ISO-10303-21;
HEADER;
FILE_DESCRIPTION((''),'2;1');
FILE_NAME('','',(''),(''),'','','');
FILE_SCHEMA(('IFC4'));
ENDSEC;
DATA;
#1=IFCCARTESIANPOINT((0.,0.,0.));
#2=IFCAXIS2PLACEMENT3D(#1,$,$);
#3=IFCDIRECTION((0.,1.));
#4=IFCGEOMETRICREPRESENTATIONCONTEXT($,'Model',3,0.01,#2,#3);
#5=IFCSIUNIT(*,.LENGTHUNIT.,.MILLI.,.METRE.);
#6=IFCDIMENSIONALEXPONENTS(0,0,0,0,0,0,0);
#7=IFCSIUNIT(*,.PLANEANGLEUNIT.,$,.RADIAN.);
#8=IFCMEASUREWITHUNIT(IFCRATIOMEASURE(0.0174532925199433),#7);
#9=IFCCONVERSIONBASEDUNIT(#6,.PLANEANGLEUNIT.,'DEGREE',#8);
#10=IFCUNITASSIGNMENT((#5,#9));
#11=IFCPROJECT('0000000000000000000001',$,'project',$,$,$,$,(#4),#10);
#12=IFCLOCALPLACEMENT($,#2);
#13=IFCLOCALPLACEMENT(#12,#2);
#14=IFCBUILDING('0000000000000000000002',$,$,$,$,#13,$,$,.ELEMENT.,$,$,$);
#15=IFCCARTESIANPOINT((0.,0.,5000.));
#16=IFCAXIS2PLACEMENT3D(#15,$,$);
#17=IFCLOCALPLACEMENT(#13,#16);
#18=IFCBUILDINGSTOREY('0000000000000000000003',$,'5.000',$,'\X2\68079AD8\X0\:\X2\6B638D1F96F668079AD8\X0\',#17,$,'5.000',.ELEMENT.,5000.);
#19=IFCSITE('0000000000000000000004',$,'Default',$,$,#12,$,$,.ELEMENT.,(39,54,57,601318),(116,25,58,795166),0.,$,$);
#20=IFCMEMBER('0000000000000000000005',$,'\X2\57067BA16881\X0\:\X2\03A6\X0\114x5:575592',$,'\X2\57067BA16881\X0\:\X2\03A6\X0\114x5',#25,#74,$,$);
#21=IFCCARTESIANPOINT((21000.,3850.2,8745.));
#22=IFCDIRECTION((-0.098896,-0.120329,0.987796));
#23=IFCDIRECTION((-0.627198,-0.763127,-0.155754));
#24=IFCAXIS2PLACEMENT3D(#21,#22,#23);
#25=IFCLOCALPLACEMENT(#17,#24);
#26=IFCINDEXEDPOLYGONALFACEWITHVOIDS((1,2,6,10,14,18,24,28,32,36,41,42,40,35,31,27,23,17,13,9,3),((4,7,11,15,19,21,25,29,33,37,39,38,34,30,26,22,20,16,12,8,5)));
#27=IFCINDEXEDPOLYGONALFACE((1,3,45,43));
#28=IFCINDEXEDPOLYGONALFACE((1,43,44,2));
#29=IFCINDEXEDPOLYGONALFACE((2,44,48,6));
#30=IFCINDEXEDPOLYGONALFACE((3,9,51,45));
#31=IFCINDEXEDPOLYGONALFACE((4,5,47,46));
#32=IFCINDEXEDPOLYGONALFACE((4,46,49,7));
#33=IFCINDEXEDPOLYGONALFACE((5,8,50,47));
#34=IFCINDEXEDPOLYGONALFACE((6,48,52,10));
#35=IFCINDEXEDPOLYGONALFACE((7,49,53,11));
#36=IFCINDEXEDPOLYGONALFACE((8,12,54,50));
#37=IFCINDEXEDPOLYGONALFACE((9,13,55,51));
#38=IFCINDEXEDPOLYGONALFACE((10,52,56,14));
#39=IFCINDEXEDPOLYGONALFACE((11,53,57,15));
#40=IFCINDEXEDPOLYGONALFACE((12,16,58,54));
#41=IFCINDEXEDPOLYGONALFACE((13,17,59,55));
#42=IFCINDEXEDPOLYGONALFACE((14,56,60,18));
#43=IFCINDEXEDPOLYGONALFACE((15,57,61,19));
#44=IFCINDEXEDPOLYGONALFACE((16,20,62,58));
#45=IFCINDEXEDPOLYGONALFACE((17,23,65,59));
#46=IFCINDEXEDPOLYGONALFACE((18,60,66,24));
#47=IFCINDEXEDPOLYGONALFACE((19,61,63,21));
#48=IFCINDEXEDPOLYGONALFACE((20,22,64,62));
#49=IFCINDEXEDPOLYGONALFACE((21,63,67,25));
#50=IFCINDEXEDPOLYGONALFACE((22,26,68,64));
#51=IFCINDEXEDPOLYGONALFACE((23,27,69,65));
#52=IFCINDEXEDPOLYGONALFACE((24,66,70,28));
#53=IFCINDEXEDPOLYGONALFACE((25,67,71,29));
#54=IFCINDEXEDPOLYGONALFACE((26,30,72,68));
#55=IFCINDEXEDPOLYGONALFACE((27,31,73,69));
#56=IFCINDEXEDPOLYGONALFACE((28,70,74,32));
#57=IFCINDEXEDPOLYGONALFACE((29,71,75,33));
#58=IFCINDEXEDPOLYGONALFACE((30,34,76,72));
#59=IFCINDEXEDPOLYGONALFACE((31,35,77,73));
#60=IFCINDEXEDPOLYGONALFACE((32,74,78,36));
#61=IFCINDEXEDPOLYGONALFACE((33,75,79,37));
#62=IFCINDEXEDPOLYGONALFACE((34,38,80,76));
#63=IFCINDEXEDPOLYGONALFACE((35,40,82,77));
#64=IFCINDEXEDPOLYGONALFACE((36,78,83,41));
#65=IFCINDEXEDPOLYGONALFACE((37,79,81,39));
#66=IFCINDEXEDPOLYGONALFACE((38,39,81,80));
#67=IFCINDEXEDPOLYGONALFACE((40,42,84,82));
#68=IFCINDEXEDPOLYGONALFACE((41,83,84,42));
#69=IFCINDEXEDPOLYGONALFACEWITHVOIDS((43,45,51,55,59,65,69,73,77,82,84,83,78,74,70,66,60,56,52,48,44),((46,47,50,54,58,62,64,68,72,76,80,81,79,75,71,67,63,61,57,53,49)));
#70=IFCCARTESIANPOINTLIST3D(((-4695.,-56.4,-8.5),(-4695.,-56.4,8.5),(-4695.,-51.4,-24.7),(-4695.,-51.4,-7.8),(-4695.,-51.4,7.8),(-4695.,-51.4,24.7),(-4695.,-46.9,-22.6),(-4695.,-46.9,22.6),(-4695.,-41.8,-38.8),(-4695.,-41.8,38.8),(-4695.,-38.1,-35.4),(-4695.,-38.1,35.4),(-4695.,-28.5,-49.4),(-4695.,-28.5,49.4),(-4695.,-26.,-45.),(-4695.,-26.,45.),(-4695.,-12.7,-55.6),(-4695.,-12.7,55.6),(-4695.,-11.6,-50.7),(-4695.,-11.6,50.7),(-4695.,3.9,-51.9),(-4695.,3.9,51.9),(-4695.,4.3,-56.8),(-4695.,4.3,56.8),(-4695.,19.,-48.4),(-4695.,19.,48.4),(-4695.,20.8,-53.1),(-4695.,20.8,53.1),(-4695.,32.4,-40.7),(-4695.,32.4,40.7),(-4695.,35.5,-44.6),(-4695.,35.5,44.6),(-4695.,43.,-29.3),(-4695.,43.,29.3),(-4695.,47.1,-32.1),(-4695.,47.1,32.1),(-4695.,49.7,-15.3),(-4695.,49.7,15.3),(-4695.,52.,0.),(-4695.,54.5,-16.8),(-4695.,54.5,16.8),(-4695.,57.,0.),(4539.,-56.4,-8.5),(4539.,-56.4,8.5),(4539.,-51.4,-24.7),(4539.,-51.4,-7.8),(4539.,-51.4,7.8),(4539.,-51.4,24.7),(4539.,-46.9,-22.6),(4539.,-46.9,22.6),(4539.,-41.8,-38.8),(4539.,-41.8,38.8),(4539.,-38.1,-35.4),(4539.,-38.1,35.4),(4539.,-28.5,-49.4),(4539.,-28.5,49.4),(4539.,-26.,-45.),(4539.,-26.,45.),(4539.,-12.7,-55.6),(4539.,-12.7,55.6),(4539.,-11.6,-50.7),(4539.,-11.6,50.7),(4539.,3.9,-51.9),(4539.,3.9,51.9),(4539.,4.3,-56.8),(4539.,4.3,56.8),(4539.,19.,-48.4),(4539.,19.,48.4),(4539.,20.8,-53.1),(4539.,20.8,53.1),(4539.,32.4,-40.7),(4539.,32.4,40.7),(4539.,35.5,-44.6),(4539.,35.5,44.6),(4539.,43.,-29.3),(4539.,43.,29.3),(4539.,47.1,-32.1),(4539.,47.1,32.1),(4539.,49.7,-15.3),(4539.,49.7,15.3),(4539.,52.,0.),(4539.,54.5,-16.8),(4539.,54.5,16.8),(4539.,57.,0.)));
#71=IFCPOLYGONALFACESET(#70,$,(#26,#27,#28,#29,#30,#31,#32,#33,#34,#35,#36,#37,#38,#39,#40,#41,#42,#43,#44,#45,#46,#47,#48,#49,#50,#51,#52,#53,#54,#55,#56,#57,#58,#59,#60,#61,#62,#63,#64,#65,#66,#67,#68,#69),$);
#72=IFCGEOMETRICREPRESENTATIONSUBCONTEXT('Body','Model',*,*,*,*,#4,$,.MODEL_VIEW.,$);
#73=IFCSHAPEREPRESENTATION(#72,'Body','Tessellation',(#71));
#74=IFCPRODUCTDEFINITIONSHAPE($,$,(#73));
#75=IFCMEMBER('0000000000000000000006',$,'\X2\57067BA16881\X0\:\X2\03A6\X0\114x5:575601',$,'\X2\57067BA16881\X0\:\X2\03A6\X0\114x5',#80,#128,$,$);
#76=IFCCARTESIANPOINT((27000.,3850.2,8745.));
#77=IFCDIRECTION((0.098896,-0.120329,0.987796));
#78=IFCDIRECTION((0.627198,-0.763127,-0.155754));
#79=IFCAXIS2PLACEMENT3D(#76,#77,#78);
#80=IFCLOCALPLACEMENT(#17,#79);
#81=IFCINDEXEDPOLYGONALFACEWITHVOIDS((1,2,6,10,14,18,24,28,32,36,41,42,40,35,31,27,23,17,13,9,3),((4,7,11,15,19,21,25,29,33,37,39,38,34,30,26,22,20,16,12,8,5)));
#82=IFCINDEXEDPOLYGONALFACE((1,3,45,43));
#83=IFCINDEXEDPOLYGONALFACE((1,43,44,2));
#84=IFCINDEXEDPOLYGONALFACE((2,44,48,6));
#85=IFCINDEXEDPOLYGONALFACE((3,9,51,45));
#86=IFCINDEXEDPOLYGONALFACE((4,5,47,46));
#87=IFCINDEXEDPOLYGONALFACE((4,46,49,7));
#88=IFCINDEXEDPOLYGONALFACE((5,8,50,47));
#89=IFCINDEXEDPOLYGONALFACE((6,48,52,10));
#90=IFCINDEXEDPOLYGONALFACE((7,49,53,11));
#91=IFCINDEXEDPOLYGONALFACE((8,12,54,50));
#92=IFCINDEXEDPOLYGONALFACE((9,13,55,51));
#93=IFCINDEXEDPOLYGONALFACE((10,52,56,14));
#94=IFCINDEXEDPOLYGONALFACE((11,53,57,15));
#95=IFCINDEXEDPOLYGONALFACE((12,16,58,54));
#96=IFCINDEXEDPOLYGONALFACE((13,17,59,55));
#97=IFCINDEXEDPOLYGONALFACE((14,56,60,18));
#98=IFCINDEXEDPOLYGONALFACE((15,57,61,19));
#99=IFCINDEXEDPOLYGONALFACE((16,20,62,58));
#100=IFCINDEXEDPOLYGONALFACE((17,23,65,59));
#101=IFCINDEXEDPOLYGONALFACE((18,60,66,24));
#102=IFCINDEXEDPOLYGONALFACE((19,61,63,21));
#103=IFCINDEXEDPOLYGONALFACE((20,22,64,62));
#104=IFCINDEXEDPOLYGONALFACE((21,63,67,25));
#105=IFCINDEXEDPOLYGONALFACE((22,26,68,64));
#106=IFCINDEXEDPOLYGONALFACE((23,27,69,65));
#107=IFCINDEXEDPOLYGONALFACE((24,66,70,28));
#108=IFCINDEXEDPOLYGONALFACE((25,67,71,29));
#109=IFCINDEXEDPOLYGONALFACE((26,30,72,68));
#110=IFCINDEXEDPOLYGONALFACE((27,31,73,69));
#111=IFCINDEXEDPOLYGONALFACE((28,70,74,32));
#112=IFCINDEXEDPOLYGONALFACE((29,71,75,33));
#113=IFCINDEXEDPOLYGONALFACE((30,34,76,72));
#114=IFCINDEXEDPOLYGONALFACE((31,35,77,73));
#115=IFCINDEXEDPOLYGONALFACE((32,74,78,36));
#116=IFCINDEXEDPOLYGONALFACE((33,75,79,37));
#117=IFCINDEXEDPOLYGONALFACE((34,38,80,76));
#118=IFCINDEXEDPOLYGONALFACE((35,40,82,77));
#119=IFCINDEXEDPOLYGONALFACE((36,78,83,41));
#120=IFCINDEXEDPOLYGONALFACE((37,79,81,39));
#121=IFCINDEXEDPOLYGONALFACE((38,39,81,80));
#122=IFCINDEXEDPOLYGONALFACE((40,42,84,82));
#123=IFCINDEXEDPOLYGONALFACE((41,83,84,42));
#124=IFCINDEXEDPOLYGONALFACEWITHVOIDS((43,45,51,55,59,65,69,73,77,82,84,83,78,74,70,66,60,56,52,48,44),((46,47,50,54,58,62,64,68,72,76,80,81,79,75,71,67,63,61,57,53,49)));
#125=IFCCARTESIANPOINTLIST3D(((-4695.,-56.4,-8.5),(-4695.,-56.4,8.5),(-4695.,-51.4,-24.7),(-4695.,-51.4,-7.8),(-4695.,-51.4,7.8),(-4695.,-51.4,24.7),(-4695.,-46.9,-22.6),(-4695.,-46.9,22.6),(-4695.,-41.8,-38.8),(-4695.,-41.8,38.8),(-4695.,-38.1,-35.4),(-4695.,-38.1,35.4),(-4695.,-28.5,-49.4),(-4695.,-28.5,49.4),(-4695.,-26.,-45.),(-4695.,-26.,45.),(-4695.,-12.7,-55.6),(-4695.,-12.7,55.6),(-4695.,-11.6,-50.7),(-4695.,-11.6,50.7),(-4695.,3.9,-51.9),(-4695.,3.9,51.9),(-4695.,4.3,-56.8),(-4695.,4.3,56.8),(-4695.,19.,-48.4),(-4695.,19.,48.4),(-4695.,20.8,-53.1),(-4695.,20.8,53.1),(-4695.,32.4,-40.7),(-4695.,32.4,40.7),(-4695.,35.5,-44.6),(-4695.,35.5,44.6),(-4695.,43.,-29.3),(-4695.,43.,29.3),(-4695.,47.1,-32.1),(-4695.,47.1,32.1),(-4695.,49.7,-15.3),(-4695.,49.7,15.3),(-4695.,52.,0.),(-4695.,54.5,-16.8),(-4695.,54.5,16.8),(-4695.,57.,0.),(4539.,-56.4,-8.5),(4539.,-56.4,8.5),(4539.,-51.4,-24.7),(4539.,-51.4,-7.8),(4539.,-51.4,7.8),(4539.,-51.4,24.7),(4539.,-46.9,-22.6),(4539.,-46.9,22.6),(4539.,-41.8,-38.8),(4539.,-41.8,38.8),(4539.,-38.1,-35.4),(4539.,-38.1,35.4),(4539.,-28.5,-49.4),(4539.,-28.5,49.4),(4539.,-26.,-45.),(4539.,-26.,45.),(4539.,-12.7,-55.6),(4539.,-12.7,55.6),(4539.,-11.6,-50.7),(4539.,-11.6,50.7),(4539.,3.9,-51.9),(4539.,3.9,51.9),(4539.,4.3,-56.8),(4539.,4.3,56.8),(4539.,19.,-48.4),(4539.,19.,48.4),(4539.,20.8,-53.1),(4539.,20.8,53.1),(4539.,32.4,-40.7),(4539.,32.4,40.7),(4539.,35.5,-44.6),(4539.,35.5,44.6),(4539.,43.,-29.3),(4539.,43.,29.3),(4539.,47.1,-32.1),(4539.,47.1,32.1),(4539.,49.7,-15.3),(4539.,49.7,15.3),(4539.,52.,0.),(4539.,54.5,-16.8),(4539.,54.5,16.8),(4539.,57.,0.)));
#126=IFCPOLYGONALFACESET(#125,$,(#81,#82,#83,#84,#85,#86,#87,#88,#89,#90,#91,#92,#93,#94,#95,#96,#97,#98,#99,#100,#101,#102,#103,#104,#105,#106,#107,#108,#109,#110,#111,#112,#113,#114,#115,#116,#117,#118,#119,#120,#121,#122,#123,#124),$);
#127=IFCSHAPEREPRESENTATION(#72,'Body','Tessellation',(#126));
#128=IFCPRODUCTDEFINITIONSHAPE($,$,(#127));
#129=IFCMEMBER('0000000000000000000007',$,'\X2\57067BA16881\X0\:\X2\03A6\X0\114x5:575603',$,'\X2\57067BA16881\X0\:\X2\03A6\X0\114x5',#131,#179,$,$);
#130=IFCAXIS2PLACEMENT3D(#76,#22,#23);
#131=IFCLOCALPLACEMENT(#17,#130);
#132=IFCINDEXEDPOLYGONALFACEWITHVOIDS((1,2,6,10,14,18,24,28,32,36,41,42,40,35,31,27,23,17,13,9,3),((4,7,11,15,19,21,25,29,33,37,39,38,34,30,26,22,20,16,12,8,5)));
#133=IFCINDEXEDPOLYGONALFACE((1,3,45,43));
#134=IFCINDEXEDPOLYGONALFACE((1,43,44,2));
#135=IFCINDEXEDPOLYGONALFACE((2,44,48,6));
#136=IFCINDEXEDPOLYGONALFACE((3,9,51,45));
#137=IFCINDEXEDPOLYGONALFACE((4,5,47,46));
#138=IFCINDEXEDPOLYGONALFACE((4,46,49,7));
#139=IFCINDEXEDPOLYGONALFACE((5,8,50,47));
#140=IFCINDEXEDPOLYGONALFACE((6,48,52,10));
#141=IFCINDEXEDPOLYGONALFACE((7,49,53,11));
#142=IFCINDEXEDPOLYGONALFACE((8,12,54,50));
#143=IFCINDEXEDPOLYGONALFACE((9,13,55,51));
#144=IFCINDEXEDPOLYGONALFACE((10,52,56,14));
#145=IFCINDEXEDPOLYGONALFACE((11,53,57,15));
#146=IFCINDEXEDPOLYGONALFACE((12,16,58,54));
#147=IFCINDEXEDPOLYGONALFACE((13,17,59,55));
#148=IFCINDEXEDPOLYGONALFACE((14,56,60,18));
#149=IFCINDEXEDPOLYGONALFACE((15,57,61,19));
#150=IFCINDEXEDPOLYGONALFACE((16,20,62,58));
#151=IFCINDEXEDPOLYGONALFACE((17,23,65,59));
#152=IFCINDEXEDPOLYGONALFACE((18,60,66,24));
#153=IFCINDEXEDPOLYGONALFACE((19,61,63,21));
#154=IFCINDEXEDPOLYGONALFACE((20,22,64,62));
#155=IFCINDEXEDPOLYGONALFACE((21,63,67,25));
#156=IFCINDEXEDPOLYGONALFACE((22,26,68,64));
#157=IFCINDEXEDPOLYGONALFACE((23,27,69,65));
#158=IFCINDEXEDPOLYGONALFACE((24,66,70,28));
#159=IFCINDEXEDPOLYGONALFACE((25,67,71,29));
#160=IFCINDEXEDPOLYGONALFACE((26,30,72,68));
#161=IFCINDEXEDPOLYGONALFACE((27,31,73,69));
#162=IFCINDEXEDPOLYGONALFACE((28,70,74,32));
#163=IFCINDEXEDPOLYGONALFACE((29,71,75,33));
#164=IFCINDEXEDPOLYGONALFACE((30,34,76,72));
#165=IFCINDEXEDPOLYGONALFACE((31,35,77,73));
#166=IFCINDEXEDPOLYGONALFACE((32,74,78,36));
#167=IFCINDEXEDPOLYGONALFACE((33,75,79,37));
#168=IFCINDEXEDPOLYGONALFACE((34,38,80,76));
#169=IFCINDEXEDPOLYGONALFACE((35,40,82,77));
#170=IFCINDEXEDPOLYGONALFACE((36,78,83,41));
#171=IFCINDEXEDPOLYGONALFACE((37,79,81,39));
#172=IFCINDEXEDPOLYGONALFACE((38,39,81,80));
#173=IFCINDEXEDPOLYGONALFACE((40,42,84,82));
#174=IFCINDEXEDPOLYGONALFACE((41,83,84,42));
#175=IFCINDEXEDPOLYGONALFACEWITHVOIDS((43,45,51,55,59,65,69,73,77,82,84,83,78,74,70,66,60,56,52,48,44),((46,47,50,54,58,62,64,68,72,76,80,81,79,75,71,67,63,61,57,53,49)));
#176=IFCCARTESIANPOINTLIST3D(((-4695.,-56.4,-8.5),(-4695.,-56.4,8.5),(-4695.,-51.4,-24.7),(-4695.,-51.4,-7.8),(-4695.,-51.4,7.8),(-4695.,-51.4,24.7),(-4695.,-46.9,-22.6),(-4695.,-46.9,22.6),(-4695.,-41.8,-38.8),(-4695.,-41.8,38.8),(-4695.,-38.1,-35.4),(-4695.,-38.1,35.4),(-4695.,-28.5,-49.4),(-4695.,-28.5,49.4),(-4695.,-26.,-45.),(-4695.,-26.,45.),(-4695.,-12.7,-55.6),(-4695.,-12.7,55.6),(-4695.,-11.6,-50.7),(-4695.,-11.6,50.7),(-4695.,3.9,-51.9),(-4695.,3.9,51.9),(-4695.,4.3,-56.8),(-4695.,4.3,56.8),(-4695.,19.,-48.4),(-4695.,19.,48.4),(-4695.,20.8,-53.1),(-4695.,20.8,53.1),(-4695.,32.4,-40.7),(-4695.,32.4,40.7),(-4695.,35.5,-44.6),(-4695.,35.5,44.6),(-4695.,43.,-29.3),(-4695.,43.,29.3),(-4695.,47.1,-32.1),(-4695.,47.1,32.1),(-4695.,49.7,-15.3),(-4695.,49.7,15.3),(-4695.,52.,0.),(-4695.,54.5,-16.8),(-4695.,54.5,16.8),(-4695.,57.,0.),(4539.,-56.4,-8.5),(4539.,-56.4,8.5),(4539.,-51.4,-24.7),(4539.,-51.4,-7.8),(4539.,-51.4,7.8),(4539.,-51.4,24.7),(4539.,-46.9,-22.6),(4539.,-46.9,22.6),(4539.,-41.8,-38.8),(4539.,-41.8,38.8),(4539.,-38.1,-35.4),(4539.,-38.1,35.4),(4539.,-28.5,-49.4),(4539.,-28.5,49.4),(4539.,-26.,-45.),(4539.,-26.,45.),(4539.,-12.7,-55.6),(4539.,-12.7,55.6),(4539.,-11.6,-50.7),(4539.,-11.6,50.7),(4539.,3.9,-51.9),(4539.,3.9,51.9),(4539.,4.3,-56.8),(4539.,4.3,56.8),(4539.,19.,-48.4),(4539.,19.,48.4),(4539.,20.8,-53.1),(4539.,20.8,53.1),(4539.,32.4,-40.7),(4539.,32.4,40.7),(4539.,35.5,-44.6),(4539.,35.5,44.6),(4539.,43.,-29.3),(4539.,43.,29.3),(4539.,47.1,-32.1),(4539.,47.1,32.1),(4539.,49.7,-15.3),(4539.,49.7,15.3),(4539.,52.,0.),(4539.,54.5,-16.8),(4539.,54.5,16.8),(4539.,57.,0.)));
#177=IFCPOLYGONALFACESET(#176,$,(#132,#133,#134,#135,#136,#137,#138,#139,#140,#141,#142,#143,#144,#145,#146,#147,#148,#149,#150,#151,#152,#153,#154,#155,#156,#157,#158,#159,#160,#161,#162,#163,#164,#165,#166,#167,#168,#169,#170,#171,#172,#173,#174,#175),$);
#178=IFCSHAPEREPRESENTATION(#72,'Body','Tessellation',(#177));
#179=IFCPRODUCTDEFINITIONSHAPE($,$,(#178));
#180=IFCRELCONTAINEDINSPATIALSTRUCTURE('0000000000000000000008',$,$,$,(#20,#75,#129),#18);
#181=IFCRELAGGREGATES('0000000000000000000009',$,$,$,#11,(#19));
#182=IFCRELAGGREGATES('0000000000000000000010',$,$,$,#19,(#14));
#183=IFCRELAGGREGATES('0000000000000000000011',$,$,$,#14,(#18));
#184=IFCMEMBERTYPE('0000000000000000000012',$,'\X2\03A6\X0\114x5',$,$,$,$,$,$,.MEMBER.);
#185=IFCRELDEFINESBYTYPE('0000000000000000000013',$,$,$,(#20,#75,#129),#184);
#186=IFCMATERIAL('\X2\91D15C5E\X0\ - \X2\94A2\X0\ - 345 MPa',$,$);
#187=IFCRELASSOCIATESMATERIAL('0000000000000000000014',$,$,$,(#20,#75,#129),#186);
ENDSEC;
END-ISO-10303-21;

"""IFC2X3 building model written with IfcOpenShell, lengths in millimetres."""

from ifc_helpers import new_model, entity, si_unit, converted_unit, direction, frame, frame_2d, origin, place, context, subcontext, project, spatial, hollow_circle, extrude, source, transform, mapped, material, type_object, type_shapes, element, save


model = new_model("IFC2X3")

# Units and contexts
model_context = context("Model", 3, precision=0.01, world=origin(), true_north=direction((0.0, 1.0)))
body_context = subcontext(model_context, "Body", "Model", "MODEL_VIEW")
ifc_project = project(units=[si_unit("LENGTHUNIT", "METRE", prefix="MILLI"), converted_unit("PLANEANGLEUNIT", "DEGREE", entity("IfcRatioMeasure", 0.0174532925199433), si_unit("PLANEANGLEUNIT", "RADIAN"), dimensions=[0, 0, 0, 0, 0, 0, 0])], contexts=[model_context])

# Site, building, storey
site_placement = place(None, origin())
site = spatial("IfcSite", under=ifc_project, at=site_placement, Name="Default", CompositionType="ELEMENT", RefLatitude=(39, 54, 57, 601318), RefLongitude=(116, 25, 58, 795166), RefElevation=0.0)
building_placement = place(site_placement, origin())
building = spatial("IfcBuilding", under=site, at=building_placement, CompositionType="ELEMENT")
storey_placement = place(building_placement, frame((0.0, 0.0, 5000.0)))
storey = spatial("IfcBuildingStorey", under=building, at=storey_placement, Name="5.000", ObjectType="标高:正负零标高", LongName="5.000", CompositionType="ELEMENT", Elevation=5000.0)

# Members
ifc_material_1 = material(Name="金属 - 钢 - 345 MPa")
member_type_1 = type_object("IfcMemberType", Name="Φ114x5", PredefinedType="MEMBER")
shared_shape_1 = source(origin(), body_context, "Body", "SweptSolid", [
    extrude(hollow_circle(Radius=57.0, WallThickness=5.0, at=frame_2d((0.0, 0.0), x_axis=(1.0, 0.0))), frame((-4695.0, 0.0, 0.0), z_axis=(1.0, 0.0, 0.0), x_axis=(0.0, 1.0, 0.0)), (0.0, 0.0, 1.0), 9234.0),
])
type_shapes(member_type_1, [shared_shape_1])
for number, where, z_axis, x_axis, name in (
    (1, (21000.0, 3850.2, 8745.0), (-0.098896, -0.120329, 0.987796), (-0.627198, -0.763127, -0.155754), "圆管梁:Φ114x5:575592"),
    (2, (27000.0, 3850.2, 8745.0), (0.098896, -0.120329, 0.987796), (0.627198, -0.763127, -0.155754), "圆管梁:Φ114x5:575601"),
    (3, (27000.0, 3850.2, 8745.0), (-0.098896, -0.120329, 0.987796), (-0.627198, -0.763127, -0.155754), "圆管梁:Φ114x5:575603"),
):
    element("IfcMember", number, at=place(storey_placement, frame(where, z_axis=z_axis, x_axis=x_axis)), inside=storey, type_object=member_type_1, material=ifc_material_1, Name=name, ObjectType="圆管梁:Φ114x5", context=body_context, shape_type="MappedRepresentation", body=[
        mapped(shared_shape_1, transform((0.0, 0.0, 0.0), scale=1.0)),
    ])

save(model, "model.ifc")
